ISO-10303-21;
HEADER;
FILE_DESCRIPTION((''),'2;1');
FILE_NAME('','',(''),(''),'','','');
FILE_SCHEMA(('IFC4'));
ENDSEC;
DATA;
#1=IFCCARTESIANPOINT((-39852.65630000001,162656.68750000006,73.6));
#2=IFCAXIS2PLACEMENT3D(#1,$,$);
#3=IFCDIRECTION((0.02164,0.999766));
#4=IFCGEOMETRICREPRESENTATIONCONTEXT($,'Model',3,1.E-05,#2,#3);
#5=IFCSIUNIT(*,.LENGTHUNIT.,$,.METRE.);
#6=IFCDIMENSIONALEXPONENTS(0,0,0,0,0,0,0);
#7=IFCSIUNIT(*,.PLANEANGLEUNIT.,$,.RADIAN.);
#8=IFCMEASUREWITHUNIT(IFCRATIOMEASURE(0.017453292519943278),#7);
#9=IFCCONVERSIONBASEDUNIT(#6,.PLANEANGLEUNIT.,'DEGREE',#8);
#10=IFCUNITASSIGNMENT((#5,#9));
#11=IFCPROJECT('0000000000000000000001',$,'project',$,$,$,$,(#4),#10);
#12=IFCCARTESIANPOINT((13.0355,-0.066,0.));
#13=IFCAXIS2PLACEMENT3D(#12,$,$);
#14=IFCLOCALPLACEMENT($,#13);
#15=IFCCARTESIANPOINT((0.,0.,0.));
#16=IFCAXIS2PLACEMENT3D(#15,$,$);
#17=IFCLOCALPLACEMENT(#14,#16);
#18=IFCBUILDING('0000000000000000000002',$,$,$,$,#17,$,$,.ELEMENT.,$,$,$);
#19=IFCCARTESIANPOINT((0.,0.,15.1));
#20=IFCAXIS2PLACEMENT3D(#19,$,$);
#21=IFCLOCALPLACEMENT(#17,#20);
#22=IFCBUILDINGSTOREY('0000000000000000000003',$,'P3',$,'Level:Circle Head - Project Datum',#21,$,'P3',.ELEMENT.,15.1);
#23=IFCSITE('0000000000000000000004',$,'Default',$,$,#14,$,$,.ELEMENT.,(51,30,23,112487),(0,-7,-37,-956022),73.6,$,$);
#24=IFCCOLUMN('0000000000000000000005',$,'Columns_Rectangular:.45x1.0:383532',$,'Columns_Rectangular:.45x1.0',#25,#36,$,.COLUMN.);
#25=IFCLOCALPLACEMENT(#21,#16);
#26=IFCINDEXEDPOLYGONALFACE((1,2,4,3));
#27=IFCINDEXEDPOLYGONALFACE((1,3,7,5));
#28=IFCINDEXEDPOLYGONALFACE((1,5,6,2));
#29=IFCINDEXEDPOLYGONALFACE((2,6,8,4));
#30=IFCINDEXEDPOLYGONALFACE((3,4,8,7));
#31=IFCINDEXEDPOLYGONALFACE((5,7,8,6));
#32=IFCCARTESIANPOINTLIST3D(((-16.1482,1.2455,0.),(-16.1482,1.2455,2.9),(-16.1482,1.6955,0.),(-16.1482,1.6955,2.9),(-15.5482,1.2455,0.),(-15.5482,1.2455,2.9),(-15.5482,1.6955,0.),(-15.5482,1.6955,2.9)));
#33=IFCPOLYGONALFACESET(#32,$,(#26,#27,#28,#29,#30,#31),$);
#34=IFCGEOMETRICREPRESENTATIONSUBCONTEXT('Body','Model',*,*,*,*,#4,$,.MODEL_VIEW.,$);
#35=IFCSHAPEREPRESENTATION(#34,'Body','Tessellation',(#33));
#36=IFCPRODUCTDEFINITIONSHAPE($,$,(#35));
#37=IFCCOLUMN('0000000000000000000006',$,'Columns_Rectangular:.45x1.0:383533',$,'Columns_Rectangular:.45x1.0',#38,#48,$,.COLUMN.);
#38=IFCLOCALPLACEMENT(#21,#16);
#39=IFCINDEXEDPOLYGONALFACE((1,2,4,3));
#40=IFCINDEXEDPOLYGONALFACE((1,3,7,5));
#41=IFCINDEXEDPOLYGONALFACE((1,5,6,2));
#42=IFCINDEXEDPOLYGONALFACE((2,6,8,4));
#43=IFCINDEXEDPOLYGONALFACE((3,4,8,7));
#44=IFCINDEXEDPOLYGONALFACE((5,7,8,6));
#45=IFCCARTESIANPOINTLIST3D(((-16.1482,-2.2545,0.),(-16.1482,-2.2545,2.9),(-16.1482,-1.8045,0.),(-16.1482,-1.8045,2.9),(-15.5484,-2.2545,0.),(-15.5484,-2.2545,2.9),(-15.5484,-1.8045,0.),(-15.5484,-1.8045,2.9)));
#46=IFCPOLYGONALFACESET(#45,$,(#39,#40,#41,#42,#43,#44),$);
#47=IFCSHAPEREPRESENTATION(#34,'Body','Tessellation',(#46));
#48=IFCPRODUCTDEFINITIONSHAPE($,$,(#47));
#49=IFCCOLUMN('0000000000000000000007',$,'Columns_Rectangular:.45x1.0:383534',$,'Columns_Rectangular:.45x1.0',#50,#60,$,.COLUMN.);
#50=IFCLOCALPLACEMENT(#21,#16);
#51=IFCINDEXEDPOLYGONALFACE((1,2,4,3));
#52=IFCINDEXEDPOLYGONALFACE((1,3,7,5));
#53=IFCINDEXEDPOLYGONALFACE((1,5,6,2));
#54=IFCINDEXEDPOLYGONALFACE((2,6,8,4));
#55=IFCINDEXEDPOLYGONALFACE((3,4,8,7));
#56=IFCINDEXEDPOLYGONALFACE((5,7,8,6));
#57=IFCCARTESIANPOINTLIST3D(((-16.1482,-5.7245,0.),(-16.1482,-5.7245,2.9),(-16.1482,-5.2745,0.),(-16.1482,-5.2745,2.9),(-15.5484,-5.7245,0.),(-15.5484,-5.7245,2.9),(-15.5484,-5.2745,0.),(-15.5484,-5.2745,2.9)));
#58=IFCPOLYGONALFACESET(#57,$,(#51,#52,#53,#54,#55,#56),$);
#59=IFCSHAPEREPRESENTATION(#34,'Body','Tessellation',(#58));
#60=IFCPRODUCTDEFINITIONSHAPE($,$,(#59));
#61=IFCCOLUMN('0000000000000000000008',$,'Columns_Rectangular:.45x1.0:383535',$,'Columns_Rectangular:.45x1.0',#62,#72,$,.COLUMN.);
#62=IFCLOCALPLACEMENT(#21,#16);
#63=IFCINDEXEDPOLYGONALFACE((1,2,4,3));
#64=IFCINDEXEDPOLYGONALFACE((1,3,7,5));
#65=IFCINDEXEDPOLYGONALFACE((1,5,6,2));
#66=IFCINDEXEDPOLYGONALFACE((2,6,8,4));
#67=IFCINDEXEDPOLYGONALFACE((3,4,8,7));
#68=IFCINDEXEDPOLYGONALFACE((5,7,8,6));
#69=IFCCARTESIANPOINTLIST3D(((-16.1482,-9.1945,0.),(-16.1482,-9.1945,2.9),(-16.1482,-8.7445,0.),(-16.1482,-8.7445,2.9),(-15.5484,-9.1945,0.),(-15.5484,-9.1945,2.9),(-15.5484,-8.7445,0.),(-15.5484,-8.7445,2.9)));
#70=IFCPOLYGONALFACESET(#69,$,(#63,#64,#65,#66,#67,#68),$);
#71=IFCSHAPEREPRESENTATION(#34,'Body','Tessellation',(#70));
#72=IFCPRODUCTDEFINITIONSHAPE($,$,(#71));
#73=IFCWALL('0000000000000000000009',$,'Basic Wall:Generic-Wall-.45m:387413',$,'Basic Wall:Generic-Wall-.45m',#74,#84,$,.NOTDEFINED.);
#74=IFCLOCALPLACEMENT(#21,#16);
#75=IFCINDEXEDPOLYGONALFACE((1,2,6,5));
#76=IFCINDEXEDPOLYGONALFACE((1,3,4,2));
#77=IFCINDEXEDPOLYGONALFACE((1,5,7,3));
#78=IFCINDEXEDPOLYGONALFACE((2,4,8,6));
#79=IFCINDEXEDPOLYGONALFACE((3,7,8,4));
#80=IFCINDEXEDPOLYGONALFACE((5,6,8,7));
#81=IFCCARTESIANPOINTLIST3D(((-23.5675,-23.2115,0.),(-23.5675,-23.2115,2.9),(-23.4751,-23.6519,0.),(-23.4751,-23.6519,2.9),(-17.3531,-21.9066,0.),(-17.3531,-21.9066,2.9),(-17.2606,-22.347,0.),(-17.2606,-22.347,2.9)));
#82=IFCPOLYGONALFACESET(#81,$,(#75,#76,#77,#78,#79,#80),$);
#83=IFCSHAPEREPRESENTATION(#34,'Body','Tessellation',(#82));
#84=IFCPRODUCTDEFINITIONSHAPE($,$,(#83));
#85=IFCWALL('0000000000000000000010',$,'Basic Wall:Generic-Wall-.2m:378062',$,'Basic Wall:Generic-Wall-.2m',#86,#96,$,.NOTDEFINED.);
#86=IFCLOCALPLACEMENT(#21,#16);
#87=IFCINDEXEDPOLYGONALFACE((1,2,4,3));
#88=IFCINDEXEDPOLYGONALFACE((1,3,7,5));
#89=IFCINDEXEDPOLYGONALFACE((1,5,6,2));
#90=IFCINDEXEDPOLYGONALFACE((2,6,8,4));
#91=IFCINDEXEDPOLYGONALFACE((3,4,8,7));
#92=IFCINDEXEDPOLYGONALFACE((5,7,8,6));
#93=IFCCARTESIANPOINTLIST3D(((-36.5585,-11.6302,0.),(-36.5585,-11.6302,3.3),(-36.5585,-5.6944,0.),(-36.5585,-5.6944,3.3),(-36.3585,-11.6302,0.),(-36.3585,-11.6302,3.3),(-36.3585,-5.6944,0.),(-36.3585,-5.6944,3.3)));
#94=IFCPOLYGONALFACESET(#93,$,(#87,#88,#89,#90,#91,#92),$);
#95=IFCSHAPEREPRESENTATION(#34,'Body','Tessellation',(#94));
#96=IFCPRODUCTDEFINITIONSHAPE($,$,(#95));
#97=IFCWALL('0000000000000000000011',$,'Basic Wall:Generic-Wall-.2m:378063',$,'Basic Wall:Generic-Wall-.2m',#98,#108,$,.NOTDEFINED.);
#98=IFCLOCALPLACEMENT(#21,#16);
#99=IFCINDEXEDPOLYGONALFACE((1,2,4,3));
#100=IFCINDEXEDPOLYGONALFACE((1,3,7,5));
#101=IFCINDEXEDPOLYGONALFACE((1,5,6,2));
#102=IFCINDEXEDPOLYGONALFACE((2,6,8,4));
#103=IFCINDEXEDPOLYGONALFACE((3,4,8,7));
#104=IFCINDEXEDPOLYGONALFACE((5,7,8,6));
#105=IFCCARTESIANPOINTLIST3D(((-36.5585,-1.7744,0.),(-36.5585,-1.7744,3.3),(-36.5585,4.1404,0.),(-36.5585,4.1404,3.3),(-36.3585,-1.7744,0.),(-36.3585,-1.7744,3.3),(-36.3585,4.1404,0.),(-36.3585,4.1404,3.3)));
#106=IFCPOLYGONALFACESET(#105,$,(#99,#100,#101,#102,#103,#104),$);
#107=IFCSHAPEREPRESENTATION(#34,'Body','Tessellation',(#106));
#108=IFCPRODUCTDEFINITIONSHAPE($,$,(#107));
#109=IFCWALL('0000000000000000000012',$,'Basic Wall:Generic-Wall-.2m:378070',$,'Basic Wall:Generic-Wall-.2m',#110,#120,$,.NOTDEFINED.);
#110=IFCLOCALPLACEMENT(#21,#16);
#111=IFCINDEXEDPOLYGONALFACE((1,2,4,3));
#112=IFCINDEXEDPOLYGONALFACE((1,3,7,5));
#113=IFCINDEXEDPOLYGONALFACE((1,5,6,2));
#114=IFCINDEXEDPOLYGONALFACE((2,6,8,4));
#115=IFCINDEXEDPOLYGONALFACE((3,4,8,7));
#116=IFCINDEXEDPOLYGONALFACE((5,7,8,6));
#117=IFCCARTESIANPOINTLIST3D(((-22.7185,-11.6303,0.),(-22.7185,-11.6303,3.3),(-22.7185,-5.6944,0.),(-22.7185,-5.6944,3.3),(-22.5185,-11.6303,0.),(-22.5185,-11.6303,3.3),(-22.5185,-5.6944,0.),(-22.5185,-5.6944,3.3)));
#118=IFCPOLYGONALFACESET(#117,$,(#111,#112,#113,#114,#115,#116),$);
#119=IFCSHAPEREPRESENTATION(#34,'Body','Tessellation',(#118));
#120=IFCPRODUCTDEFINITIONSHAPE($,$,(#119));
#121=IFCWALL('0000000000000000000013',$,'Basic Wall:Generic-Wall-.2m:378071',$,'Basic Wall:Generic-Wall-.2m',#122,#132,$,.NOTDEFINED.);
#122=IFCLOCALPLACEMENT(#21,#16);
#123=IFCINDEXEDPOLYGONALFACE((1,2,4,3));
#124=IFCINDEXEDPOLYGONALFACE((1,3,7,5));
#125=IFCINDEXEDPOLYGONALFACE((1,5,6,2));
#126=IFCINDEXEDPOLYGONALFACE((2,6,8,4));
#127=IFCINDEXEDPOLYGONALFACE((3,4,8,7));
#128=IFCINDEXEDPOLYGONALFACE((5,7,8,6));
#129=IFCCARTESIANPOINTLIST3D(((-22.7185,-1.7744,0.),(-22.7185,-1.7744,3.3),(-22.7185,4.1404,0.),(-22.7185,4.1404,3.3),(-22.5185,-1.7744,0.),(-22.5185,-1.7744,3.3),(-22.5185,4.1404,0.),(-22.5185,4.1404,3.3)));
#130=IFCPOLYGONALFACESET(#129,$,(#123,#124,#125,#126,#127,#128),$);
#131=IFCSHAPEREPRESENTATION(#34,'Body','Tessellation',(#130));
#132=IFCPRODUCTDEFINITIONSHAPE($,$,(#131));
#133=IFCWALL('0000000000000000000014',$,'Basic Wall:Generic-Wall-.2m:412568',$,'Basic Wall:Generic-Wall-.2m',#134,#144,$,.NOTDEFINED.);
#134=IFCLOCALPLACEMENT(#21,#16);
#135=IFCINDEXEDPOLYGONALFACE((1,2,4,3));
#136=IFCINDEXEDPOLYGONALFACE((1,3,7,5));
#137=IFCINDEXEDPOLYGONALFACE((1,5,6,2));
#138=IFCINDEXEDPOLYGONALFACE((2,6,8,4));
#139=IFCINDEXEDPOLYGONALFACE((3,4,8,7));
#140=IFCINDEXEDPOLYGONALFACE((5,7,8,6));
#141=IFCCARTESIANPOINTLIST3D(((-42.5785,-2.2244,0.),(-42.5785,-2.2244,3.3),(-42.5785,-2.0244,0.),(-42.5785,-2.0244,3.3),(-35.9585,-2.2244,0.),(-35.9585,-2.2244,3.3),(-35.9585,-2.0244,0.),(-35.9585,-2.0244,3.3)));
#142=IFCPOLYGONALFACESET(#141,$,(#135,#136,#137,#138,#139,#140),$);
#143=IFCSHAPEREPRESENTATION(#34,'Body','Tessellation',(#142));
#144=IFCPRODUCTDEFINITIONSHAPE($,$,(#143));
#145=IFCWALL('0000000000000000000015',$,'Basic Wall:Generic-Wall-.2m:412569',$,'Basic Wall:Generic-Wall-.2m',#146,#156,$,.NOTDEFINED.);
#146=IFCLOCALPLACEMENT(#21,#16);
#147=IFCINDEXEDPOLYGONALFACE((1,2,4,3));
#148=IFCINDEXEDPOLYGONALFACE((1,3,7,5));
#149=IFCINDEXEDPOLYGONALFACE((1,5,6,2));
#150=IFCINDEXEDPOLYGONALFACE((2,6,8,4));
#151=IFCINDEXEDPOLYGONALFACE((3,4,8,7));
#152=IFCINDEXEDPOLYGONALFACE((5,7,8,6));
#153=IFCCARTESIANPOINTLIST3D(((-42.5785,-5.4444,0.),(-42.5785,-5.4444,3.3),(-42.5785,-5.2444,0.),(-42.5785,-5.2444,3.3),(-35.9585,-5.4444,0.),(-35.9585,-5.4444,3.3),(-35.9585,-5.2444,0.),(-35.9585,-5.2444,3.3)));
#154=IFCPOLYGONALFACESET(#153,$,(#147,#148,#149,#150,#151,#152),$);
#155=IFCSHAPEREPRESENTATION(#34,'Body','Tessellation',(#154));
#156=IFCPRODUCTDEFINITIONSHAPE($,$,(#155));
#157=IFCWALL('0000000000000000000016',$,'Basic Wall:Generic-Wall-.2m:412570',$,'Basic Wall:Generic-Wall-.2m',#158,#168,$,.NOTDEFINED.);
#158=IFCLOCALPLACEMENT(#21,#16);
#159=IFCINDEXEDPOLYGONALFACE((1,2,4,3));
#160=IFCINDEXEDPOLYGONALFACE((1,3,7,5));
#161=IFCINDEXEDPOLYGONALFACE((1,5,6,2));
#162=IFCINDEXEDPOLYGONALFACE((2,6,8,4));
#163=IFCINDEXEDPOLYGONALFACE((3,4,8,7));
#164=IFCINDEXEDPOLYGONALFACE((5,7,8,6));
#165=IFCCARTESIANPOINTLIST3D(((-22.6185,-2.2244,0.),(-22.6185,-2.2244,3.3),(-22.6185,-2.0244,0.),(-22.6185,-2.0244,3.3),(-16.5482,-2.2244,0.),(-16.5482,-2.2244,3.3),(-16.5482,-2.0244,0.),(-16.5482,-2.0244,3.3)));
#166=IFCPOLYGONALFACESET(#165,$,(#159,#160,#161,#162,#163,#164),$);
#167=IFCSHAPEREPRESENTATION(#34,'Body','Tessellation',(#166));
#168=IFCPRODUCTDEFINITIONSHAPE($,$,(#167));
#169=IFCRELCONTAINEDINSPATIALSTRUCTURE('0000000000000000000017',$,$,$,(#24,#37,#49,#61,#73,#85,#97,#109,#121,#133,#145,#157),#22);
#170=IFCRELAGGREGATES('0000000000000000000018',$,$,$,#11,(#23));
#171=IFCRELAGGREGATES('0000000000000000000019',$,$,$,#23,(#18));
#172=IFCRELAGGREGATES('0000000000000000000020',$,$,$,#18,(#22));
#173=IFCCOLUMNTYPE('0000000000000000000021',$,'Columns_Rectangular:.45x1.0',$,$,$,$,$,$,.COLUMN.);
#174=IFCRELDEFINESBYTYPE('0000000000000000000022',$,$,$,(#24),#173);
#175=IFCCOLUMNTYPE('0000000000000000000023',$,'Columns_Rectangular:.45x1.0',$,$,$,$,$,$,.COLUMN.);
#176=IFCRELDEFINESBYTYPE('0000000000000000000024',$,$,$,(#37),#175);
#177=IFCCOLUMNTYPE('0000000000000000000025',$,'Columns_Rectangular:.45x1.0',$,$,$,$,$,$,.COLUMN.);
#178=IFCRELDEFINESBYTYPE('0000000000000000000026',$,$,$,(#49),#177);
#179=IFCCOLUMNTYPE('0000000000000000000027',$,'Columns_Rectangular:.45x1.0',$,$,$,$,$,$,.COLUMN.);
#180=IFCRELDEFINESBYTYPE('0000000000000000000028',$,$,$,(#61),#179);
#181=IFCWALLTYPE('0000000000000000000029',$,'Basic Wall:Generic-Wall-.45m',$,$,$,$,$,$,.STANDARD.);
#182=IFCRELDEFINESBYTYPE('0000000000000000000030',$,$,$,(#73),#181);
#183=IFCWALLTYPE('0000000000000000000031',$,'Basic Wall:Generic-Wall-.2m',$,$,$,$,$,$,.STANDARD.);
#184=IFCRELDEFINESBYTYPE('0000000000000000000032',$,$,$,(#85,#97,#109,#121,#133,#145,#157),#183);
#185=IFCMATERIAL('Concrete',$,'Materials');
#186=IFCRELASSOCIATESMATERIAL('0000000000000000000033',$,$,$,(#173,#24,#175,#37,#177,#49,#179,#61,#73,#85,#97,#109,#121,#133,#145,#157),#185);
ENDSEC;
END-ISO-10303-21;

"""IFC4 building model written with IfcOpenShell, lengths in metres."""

from ifc_helpers import new_model, entity, si_unit, converted_unit, direction, frame, origin, place, context, subcontext, project, spatial, indexed_curve, outline, extrude, source, transform, mapped, material, type_object, type_shapes, element, save


model = new_model("IFC4")

# Units and contexts
model_context = context("Model", 3, precision=1e-05, world=frame((-39852.65630000001, 162656.68750000006, 73.6)), true_north=direction((0.02164, 0.999766)))
body_context = subcontext(model_context, "Body", "Model", "MODEL_VIEW")
ifc_project = project(units=[si_unit("LENGTHUNIT", "METRE"), converted_unit("PLANEANGLEUNIT", "DEGREE", entity("IfcRatioMeasure", 0.017453292519943278), si_unit("PLANEANGLEUNIT", "RADIAN"), dimensions=[0, 0, 0, 0, 0, 0, 0])], contexts=[model_context])

# Site, building, storey
site_placement = place(None, frame((13.0355, -0.066, 0.0)))
site = spatial("IfcSite", under=ifc_project, at=site_placement, Name="Default", CompositionType="ELEMENT", RefLatitude=(51, 30, 23, 112487), RefLongitude=(0, -7, -37, -956022), RefElevation=73.6)
building_placement = place(site_placement, origin())
building = spatial("IfcBuilding", under=site, at=building_placement, CompositionType="ELEMENT")
storey_placement = place(building_placement, frame((0.0, 0.0, 15.1)))
storey = spatial("IfcBuildingStorey", under=building, at=storey_placement, Name="P3", ObjectType="Level:Circle Head - Project Datum", LongName="P3", CompositionType="ELEMENT", Elevation=15.1)

# Columns
ifc_material = material(Name="Concrete", Category="Materials")
column_type_1 = type_object("IfcColumnType", Name="Columns_Rectangular:.45x1.0", PredefinedType="COLUMN", material=ifc_material)
shared_shape_1 = source(origin(), body_context, "Body", "SweptSolid", [
    extrude(outline(indexed_curve([(-0.225, -0.3), (0.225, -0.3), (0.225, 0.3), (-0.225, 0.3), (-0.225, -0.3)], self_intersect=False)), frame((-15.8482, 1.4705, 15.1), z_axis=(0.0, 0.0, 1.0), x_axis=(0.0, -1.0, 0.0)), (0.0, 0.0, 1.0), 2.9),
])
type_shapes(column_type_1, [shared_shape_1])
column_1_placement = place(storey_placement, frame((0.0, 0.0, -15.1)))
element("IfcColumn", 1, at=column_1_placement, inside=storey, type_object=column_type_1, material=ifc_material, Name="Columns_Rectangular:.45x1.0:383532", ObjectType="Columns_Rectangular:.45x1.0", PredefinedType="COLUMN", context=body_context, shape_type="MappedRepresentation", body=[
    mapped(shared_shape_1, transform((0.0, 0.0, 0.0), scale=1.0)),
])
column_type_2 = type_object("IfcColumnType", Name="Columns_Rectangular:.45x1.0", PredefinedType="COLUMN", material=ifc_material)
shared_shape_2 = source(origin(), body_context, "Body", "SweptSolid", [
    extrude(outline(indexed_curve([(-0.225, -0.2999), (0.225, -0.2999), (0.225, 0.2999), (-0.225, 0.2999), (-0.225, -0.2999)], self_intersect=False)), frame((-15.8483, -2.0295, 15.1), z_axis=(0.0, 0.0, 1.0), x_axis=(0.0, -1.0, 0.0)), (0.0, 0.0, 1.0), 2.9),
])
type_shapes(column_type_2, [shared_shape_2])
column_2_placement = place(storey_placement, frame((0.0, 0.0, -15.1)))
element("IfcColumn", 2, at=column_2_placement, inside=storey, type_object=column_type_2, material=ifc_material, Name="Columns_Rectangular:.45x1.0:383533", ObjectType="Columns_Rectangular:.45x1.0", PredefinedType="COLUMN", context=body_context, shape_type="MappedRepresentation", body=[
    mapped(shared_shape_2, transform((0.0, 0.0, 0.0), scale=1.0)),
])
column_type_3 = type_object("IfcColumnType", Name="Columns_Rectangular:.45x1.0", PredefinedType="COLUMN", material=ifc_material)
shared_shape_3 = source(origin(), body_context, "Body", "SweptSolid", [
    extrude(outline(indexed_curve([(-0.225, -0.2999), (0.225, -0.2999), (0.225, 0.2999), (-0.225, 0.2999), (-0.225, -0.2999)], self_intersect=False)), frame((-15.8483, -5.4995, 15.1), z_axis=(0.0, 0.0, 1.0), x_axis=(0.0, -1.0, 0.0)), (0.0, 0.0, 1.0), 2.9),
])
type_shapes(column_type_3, [shared_shape_3])
column_3_placement = place(storey_placement, frame((0.0, 0.0, -15.1)))
element("IfcColumn", 3, at=column_3_placement, inside=storey, type_object=column_type_3, material=ifc_material, Name="Columns_Rectangular:.45x1.0:383534", ObjectType="Columns_Rectangular:.45x1.0", PredefinedType="COLUMN", context=body_context, shape_type="MappedRepresentation", body=[
    mapped(shared_shape_3, transform((0.0, 0.0, 0.0), scale=1.0)),
])
column_type_4 = type_object("IfcColumnType", Name="Columns_Rectangular:.45x1.0", PredefinedType="COLUMN", material=ifc_material)
shared_shape_4 = source(origin(), body_context, "Body", "SweptSolid", [
    extrude(outline(indexed_curve([(-0.225, -0.2999), (0.225, -0.2999), (0.225, 0.2999), (-0.225, 0.2999), (-0.225, -0.2999)], self_intersect=False)), frame((-15.8483, -8.9695, 15.1), z_axis=(0.0, 0.0, 1.0), x_axis=(0.0, -1.0, 0.0)), (0.0, 0.0, 1.0), 2.9),
])
type_shapes(column_type_4, [shared_shape_4])
column_4_placement = place(storey_placement, frame((0.0, 0.0, -15.1)))
element("IfcColumn", 4, at=column_4_placement, inside=storey, type_object=column_type_4, material=ifc_material, Name="Columns_Rectangular:.45x1.0:383535", ObjectType="Columns_Rectangular:.45x1.0", PredefinedType="COLUMN", context=body_context, shape_type="MappedRepresentation", body=[
    mapped(shared_shape_4, transform((0.0, 0.0, 0.0), scale=1.0)),
])

# Walls
wall_type_1 = type_object("IfcWallType", Name="Basic Wall:Generic-Wall-.45m", PredefinedType="STANDARD")
wall_1_placement = place(storey_placement, frame((-23.5213, -23.4317, 0.0), z_axis=(0.0, 0.0, 1.0), x_axis=(0.978657, 0.2055, 0.0)))
element("IfcWall", 5, at=wall_1_placement, inside=storey, type_object=wall_type_1, material=ifc_material, Name="Basic Wall:Generic-Wall-.45m:387413", ObjectType="Basic Wall:Generic-Wall-.45m", PredefinedType="NOTDEFINED", context=body_context, shape_type="SweptSolid", body=[
    extrude(outline(indexed_curve([(6.35, 0.225), (0.0, 0.225), (0.0, -0.225), (6.35, -0.225), (6.35, 0.225)], self_intersect=False)), origin(), (0.0, 0.0, 1.0), 2.9),
])
wall_type_2 = type_object("IfcWallType", Name="Basic Wall:Generic-Wall-.2m", PredefinedType="STANDARD")
wall_2_placement = place(storey_placement, frame((-36.4585, -5.6944, 0.0), z_axis=(0.0, 0.0, 1.0), x_axis=(0.0, -1.0, 0.0)))
element("IfcWall", 6, at=wall_2_placement, inside=storey, type_object=wall_type_2, material=ifc_material, Name="Basic Wall:Generic-Wall-.2m:378062", ObjectType="Basic Wall:Generic-Wall-.2m", PredefinedType="NOTDEFINED", context=body_context, shape_type="SweptSolid", body=[
    extrude(outline(indexed_curve([(5.9357, 0.1), (0.0, 0.1), (0.0, -0.1), (5.9357, -0.1), (5.9357, 0.1)], self_intersect=False)), origin(), (0.0, 0.0, 1.0), 3.3),
])
wall_3_placement = place(storey_placement, frame((-36.4585, -1.7744, 0.0), z_axis=(0.0, 0.0, 1.0), x_axis=(0.0, 1.0, 0.0)))
element("IfcWall", 7, at=wall_3_placement, inside=storey, type_object=wall_type_2, material=ifc_material, Name="Basic Wall:Generic-Wall-.2m:378063", ObjectType="Basic Wall:Generic-Wall-.2m", PredefinedType="NOTDEFINED", context=body_context, shape_type="SweptSolid", body=[
    extrude(outline(indexed_curve([(5.9149, 0.1), (0.0, 0.1), (0.0, -0.1), (5.9149, -0.1), (5.9149, 0.1)], self_intersect=False)), origin(), (0.0, 0.0, 1.0), 3.3),
])
wall_4_placement = place(storey_placement, frame((-22.6185, -5.6944, 0.0), z_axis=(0.0, 0.0, 1.0), x_axis=(0.0, -1.0, 0.0)))
element("IfcWall", 8, at=wall_4_placement, inside=storey, type_object=wall_type_2, material=ifc_material, Name="Basic Wall:Generic-Wall-.2m:378070", ObjectType="Basic Wall:Generic-Wall-.2m", PredefinedType="NOTDEFINED", context=body_context, shape_type="SweptSolid", body=[
    extrude(outline(indexed_curve([(5.9359, 0.1), (0.0, 0.1), (0.0, -0.1), (5.9359, -0.1), (5.9359, 0.1)], self_intersect=False)), origin(), (0.0, 0.0, 1.0), 3.3),
])
wall_5_placement = place(storey_placement, frame((-22.6185, -1.7744, 0.0), z_axis=(0.0, 0.0, 1.0), x_axis=(0.0, 1.0, 0.0)))
element("IfcWall", 9, at=wall_5_placement, inside=storey, type_object=wall_type_2, material=ifc_material, Name="Basic Wall:Generic-Wall-.2m:378071", ObjectType="Basic Wall:Generic-Wall-.2m", PredefinedType="NOTDEFINED", context=body_context, shape_type="SweptSolid", body=[
    extrude(outline(indexed_curve([(5.9149, 0.1), (0.0, 0.1), (0.0, -0.1), (5.9149, -0.1), (5.9149, 0.1)], self_intersect=False)), origin(), (0.0, 0.0, 1.0), 3.3),
])
wall_6_placement = place(storey_placement, frame((-35.9585, -2.1244, 0.0), z_axis=(0.0, 0.0, 1.0), x_axis=(-1.0, 0.0, 0.0)))
element("IfcWall", 10, at=wall_6_placement, inside=storey, type_object=wall_type_2, material=ifc_material, Name="Basic Wall:Generic-Wall-.2m:412568", ObjectType="Basic Wall:Generic-Wall-.2m", PredefinedType="NOTDEFINED", context=body_context, shape_type="SweptSolid", body=[
    extrude(outline(indexed_curve([(6.6201, 0.1), (0.0, 0.1), (0.0, -0.1), (6.6201, -0.1), (6.6201, 0.1)], self_intersect=False)), origin(), (0.0, 0.0, 1.0), 3.3),
])
wall_7_placement = place(storey_placement, frame((-35.9585, -5.3444, 0.0), z_axis=(0.0, 0.0, 1.0), x_axis=(-1.0, 0.0, 0.0)))
element("IfcWall", 11, at=wall_7_placement, inside=storey, type_object=wall_type_2, material=ifc_material, Name="Basic Wall:Generic-Wall-.2m:412569", ObjectType="Basic Wall:Generic-Wall-.2m", PredefinedType="NOTDEFINED", context=body_context, shape_type="SweptSolid", body=[
    extrude(outline(indexed_curve([(6.62, 0.1), (0.0, 0.1), (0.0, -0.1), (6.62, -0.1), (6.62, 0.1)], self_intersect=False)), origin(), (0.0, 0.0, 1.0), 3.3),
])
wall_8_placement = place(storey_placement, frame((-22.6185, -2.1244, 0.0)))
element("IfcWall", 12, at=wall_8_placement, inside=storey, type_object=wall_type_2, material=ifc_material, Name="Basic Wall:Generic-Wall-.2m:412570", ObjectType="Basic Wall:Generic-Wall-.2m", PredefinedType="NOTDEFINED", context=body_context, shape_type="SweptSolid", body=[
    extrude(outline(indexed_curve([(6.0702, 0.1), (0.0, 0.1), (0.0, -0.1), (6.0702, -0.1), (6.0702, 0.1)], self_intersect=False)), origin(), (0.0, 0.0, 1.0), 3.3),
])

save(model, "model.ifc")
